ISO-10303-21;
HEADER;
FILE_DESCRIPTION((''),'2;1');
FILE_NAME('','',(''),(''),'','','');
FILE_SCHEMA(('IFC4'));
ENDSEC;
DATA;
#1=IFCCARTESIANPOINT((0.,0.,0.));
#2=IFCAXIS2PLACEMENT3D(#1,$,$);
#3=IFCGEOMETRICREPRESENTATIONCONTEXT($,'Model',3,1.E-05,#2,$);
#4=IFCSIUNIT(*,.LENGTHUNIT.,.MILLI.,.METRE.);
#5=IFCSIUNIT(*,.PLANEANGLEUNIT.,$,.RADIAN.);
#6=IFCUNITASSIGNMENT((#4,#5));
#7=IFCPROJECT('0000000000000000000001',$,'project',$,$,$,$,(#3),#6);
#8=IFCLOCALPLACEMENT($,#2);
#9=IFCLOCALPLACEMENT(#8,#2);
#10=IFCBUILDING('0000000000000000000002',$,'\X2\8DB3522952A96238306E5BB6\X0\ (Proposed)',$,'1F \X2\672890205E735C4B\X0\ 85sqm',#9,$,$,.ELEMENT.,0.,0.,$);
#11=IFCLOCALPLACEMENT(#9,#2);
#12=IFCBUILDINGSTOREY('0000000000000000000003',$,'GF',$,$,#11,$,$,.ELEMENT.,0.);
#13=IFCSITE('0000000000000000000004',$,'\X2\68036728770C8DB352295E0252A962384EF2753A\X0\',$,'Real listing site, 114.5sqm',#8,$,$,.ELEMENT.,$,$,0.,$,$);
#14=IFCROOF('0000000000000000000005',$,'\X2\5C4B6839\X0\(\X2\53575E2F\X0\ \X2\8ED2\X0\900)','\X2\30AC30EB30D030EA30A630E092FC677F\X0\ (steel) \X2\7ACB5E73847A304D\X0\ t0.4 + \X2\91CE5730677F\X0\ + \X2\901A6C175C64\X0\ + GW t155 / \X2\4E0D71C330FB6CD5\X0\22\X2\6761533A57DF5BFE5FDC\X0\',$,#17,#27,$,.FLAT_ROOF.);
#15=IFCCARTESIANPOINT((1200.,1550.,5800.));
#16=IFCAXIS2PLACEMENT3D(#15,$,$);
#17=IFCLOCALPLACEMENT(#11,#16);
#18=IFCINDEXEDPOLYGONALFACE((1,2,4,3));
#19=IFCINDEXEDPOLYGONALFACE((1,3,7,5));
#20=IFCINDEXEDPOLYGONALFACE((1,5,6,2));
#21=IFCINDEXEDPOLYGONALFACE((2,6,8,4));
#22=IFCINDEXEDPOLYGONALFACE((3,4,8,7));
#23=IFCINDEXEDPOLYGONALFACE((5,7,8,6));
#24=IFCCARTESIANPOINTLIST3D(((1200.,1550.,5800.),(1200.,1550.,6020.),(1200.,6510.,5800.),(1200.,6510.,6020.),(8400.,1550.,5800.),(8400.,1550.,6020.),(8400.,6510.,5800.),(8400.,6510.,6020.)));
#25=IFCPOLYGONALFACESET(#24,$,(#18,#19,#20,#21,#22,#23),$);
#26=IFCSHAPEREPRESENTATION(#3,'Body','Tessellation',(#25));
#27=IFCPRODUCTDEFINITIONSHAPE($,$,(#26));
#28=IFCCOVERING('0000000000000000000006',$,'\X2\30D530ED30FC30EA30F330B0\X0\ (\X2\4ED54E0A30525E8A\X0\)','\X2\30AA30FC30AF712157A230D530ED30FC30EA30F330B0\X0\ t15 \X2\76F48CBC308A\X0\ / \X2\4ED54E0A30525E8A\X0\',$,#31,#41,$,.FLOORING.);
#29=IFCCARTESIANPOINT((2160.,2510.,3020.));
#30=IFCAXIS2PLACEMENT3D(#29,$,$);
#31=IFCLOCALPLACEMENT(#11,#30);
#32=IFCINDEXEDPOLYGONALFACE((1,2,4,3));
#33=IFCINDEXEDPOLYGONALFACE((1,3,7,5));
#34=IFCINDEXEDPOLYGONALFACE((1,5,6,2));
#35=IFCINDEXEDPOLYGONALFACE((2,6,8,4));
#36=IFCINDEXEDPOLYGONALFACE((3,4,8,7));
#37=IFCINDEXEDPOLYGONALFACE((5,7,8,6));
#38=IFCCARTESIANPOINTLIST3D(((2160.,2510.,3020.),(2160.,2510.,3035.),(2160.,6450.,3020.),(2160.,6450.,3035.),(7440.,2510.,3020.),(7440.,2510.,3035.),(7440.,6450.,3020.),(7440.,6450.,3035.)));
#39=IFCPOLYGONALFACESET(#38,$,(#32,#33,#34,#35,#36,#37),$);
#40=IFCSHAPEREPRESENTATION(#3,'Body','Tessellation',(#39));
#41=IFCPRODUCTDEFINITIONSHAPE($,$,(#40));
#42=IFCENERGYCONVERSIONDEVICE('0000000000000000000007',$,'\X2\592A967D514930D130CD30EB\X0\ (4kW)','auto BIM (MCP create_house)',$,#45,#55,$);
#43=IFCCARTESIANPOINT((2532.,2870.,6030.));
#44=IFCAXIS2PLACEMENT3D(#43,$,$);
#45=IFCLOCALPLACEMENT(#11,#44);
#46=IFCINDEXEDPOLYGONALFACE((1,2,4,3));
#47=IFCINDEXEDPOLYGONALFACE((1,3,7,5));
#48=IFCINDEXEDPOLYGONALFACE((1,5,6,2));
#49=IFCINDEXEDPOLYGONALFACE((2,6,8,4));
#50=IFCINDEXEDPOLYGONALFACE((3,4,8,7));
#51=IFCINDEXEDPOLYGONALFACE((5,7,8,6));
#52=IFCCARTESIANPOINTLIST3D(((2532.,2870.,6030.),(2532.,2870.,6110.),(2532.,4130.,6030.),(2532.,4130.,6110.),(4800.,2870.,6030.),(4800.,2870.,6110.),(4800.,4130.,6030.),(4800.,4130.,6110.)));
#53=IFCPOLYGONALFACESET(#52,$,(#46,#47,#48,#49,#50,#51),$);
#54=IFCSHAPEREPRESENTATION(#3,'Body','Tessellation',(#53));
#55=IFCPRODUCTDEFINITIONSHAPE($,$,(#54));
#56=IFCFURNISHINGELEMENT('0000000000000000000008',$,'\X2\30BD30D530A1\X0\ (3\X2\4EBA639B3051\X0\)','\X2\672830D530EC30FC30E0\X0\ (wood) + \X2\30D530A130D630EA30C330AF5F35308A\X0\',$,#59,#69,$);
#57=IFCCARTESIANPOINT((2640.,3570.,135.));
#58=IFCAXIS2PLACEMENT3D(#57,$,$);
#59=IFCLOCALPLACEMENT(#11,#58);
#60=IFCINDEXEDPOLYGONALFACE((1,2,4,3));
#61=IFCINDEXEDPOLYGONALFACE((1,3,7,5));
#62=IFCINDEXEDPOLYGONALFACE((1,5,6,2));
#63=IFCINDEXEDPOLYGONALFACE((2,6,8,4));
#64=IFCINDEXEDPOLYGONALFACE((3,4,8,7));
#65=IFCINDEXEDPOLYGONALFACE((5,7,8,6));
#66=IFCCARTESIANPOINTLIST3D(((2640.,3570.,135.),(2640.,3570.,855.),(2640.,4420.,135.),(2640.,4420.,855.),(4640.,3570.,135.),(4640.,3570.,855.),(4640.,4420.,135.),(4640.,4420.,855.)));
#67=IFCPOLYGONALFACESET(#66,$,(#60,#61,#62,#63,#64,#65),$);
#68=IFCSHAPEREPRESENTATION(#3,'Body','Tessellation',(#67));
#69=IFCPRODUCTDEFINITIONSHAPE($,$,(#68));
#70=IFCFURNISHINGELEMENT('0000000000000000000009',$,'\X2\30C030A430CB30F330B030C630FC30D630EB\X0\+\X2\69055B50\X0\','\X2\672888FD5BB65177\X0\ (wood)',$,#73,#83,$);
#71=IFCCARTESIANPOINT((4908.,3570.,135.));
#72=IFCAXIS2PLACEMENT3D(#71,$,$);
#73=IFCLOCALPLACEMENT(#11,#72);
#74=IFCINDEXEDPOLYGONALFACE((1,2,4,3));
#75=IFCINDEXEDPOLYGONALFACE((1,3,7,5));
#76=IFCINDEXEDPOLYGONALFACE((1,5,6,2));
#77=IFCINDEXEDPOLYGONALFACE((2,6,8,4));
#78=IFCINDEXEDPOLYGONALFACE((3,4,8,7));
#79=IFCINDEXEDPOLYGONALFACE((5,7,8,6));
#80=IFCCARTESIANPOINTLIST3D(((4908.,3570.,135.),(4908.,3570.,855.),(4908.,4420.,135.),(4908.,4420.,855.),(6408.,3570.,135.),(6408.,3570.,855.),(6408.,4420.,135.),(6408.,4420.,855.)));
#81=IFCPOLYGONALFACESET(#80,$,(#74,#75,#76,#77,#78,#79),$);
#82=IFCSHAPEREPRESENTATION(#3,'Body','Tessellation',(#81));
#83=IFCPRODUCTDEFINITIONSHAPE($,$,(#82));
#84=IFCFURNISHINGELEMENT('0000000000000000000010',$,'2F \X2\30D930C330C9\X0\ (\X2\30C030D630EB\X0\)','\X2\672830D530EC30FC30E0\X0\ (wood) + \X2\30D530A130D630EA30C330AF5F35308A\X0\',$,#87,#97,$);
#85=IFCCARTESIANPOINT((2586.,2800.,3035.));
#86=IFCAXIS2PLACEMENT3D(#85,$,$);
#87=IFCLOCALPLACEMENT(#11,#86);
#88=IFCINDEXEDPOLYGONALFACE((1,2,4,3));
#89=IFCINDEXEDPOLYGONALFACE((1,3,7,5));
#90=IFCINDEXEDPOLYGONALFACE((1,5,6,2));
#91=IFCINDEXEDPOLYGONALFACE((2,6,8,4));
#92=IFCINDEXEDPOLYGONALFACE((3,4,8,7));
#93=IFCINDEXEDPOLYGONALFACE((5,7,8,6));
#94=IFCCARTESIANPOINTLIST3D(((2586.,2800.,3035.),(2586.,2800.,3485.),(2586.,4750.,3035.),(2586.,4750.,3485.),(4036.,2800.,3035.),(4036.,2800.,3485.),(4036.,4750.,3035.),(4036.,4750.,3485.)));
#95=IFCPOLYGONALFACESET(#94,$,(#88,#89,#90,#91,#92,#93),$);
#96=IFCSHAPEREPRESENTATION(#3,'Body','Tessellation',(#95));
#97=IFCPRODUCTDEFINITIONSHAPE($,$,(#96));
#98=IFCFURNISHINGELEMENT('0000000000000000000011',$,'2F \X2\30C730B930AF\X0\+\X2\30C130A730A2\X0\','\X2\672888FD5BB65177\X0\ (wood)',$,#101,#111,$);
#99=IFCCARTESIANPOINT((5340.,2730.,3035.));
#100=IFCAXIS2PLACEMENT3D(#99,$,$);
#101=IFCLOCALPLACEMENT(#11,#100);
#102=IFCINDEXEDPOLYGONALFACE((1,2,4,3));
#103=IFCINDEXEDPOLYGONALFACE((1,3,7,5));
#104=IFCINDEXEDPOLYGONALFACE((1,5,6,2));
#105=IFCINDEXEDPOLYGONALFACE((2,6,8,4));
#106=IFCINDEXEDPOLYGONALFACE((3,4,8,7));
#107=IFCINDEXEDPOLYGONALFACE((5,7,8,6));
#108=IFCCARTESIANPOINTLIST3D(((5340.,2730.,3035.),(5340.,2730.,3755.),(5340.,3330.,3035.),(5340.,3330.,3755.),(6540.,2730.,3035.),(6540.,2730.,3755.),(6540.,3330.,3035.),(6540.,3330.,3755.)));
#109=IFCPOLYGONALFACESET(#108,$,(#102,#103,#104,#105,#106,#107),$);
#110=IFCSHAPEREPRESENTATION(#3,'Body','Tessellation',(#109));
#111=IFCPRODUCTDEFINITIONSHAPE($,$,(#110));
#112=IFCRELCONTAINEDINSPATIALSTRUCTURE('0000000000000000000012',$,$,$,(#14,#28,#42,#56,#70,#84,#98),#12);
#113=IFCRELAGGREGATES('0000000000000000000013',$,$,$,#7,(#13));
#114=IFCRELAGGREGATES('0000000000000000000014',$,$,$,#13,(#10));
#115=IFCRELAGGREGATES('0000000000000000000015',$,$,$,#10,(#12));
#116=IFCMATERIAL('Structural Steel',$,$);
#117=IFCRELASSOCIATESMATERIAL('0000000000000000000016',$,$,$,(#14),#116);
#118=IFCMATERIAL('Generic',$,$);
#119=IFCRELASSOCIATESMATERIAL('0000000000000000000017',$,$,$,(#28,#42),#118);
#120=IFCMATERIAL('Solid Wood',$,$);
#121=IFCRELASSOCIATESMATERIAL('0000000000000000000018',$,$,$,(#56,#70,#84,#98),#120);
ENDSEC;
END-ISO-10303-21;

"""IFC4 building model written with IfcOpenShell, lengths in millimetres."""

from ifc_helpers import new_model, si_unit, frame, frame_2d, origin, place, context, project, spatial, rectangle, extrude, material, element, save


model = new_model("IFC4")

# Units and contexts
model_context = context("Model", 3, precision=1e-05, world=origin())
ifc_project = project(units=[si_unit("LENGTHUNIT", "METRE", prefix="MILLI"), si_unit("PLANEANGLEUNIT", "RADIAN")], contexts=[model_context])

# Site, building, storey
site_placement = place(None, origin())
site = spatial("IfcSite", under=ifc_project, at=site_placement, Name="栃木県足利市助戸仲町", ObjectType="Real listing site, 114.5sqm", CompositionType="ELEMENT", RefElevation=0.0)
building_placement = place(site_placement, origin())
building = spatial("IfcBuilding", under=site, at=building_placement, Name="足利助戸の家 (Proposed)", ObjectType="1F 木造平屋 85sqm", CompositionType="ELEMENT", ElevationOfRefHeight=0.0, ElevationOfTerrain=0.0)
storey_placement = place(building_placement, origin())
storey = spatial("IfcBuildingStorey", under=building, at=storey_placement, Name="GF", CompositionType="ELEMENT", Elevation=0.0)

# Shared definitions
ifc_material_1 = material(Name="Solid Wood")

# Shared definitions
ifc_material_2 = material(Name="Generic")

# Roof
ifc_material_3 = material(Name="Structural Steel")
for number, where, name in (
    (1, (1200.0, 1550.0, 5800.0), "屋根(南帯 軒900)"),
):
    element("IfcRoof", number, at=place(storey_placement, frame(where)), inside=storey, material=ifc_material_3, Name=name, Description="ガルバリウム鋼板 (steel) 立平葺き t0.4 + 野地板 + 通気層 + GW t155 / 不燃・法22条区域対応", PredefinedType="FLAT_ROOF", context=model_context, shape_type="SweptSolid", body=[
        extrude(rectangle(XDim=7200.0, YDim=4960.0, at=frame_2d((3600.0, 2480.0))), frame((1200.0, 1550.0, 5800.0)), (0.0, 0.0, 1.0), 220.0),
    ])

# Covering
covering_placement = place(storey_placement, frame((2160.0, 2510.0, 3020.0)))
element("IfcCovering", 2, at=covering_placement, inside=storey, material=ifc_material_2, Name="フローリング (仕上げ床)", Description="オーク無垢フローリング t15 直貼り / 仕上げ床", PredefinedType="FLOORING", context=model_context, shape_type="SweptSolid", body=[
    extrude(rectangle(XDim=5280.0, YDim=3940.0, at=frame_2d((2640.0, 1970.0))), frame((2160.0, 2510.0, 3020.0)), (0.0, 0.0, 1.0), 15.0),
])

# Energy conversion device
energy_conversion_device_placement = place(storey_placement, frame((2532.0, 2870.0, 6030.0)))
element("IfcEnergyConversionDevice", 3, at=energy_conversion_device_placement, inside=storey, material=ifc_material_2, Name="太陽光パネル (4kW)", Description="auto BIM (MCP create_house)", context=model_context, shape_type="SweptSolid", body=[
    extrude(rectangle(XDim=2268.0, YDim=1260.0, at=frame_2d((1134.0, 630.0))), frame((2532.0, 2870.0, 6030.0)), (0.0, 0.0, 1.0), 80.0),
])

# Furnishing elements
furnishing_1_placement = place(storey_placement, frame((2640.0, 3570.0, 135.0)))
element("IfcFurnishingElement", 4, at=furnishing_1_placement, inside=storey, material=ifc_material_1, Name="ソファ (3人掛け)", Description="木フレーム (wood) + ファブリック張り", context=model_context, shape_type="SweptSolid", body=[
    extrude(rectangle(XDim=2000.0, YDim=850.0, at=frame_2d((1000.0, 425.0))), frame((2640.0, 3570.0, 135.0)), (0.0, 0.0, 1.0), 720.0),
])
furnishing_2_placement = place(storey_placement, frame((4908.0, 3570.0, 135.0)))
element("IfcFurnishingElement", 5, at=furnishing_2_placement, inside=storey, material=ifc_material_1, Name="ダイニングテーブル+椅子", Description="木製家具 (wood)", context=model_context, shape_type="SweptSolid", body=[
    extrude(rectangle(XDim=1500.0, YDim=850.0, at=frame_2d((750.0, 425.0))), frame((4908.0, 3570.0, 135.0)), (0.0, 0.0, 1.0), 720.0),
])
furnishing_3_placement = place(storey_placement, frame((2586.0, 2800.0, 3035.0)))
element("IfcFurnishingElement", 6, at=furnishing_3_placement, inside=storey, material=ifc_material_1, Name="2F ベッド (ダブル)", Description="木フレーム (wood) + ファブリック張り", context=model_context, shape_type="SweptSolid", body=[
    extrude(rectangle(XDim=1450.0, YDim=1950.0, at=frame_2d((725.0, 975.0))), frame((2586.0, 2800.0, 3035.0)), (0.0, 0.0, 1.0), 450.0),
])
furnishing_4_placement = place(storey_placement, frame((5340.0, 2730.0, 3035.0)))
element("IfcFurnishingElement", 7, at=furnishing_4_placement, inside=storey, material=ifc_material_1, Name="2F デスク+チェア", Description="木製家具 (wood)", context=model_context, shape_type="SweptSolid", body=[
    extrude(rectangle(XDim=1200.0, YDim=600.0, at=frame_2d((600.0, 300.0))), frame((5340.0, 2730.0, 3035.0)), (0.0, 0.0, 1.0), 720.0),
])

save(model, "model.ifc")
